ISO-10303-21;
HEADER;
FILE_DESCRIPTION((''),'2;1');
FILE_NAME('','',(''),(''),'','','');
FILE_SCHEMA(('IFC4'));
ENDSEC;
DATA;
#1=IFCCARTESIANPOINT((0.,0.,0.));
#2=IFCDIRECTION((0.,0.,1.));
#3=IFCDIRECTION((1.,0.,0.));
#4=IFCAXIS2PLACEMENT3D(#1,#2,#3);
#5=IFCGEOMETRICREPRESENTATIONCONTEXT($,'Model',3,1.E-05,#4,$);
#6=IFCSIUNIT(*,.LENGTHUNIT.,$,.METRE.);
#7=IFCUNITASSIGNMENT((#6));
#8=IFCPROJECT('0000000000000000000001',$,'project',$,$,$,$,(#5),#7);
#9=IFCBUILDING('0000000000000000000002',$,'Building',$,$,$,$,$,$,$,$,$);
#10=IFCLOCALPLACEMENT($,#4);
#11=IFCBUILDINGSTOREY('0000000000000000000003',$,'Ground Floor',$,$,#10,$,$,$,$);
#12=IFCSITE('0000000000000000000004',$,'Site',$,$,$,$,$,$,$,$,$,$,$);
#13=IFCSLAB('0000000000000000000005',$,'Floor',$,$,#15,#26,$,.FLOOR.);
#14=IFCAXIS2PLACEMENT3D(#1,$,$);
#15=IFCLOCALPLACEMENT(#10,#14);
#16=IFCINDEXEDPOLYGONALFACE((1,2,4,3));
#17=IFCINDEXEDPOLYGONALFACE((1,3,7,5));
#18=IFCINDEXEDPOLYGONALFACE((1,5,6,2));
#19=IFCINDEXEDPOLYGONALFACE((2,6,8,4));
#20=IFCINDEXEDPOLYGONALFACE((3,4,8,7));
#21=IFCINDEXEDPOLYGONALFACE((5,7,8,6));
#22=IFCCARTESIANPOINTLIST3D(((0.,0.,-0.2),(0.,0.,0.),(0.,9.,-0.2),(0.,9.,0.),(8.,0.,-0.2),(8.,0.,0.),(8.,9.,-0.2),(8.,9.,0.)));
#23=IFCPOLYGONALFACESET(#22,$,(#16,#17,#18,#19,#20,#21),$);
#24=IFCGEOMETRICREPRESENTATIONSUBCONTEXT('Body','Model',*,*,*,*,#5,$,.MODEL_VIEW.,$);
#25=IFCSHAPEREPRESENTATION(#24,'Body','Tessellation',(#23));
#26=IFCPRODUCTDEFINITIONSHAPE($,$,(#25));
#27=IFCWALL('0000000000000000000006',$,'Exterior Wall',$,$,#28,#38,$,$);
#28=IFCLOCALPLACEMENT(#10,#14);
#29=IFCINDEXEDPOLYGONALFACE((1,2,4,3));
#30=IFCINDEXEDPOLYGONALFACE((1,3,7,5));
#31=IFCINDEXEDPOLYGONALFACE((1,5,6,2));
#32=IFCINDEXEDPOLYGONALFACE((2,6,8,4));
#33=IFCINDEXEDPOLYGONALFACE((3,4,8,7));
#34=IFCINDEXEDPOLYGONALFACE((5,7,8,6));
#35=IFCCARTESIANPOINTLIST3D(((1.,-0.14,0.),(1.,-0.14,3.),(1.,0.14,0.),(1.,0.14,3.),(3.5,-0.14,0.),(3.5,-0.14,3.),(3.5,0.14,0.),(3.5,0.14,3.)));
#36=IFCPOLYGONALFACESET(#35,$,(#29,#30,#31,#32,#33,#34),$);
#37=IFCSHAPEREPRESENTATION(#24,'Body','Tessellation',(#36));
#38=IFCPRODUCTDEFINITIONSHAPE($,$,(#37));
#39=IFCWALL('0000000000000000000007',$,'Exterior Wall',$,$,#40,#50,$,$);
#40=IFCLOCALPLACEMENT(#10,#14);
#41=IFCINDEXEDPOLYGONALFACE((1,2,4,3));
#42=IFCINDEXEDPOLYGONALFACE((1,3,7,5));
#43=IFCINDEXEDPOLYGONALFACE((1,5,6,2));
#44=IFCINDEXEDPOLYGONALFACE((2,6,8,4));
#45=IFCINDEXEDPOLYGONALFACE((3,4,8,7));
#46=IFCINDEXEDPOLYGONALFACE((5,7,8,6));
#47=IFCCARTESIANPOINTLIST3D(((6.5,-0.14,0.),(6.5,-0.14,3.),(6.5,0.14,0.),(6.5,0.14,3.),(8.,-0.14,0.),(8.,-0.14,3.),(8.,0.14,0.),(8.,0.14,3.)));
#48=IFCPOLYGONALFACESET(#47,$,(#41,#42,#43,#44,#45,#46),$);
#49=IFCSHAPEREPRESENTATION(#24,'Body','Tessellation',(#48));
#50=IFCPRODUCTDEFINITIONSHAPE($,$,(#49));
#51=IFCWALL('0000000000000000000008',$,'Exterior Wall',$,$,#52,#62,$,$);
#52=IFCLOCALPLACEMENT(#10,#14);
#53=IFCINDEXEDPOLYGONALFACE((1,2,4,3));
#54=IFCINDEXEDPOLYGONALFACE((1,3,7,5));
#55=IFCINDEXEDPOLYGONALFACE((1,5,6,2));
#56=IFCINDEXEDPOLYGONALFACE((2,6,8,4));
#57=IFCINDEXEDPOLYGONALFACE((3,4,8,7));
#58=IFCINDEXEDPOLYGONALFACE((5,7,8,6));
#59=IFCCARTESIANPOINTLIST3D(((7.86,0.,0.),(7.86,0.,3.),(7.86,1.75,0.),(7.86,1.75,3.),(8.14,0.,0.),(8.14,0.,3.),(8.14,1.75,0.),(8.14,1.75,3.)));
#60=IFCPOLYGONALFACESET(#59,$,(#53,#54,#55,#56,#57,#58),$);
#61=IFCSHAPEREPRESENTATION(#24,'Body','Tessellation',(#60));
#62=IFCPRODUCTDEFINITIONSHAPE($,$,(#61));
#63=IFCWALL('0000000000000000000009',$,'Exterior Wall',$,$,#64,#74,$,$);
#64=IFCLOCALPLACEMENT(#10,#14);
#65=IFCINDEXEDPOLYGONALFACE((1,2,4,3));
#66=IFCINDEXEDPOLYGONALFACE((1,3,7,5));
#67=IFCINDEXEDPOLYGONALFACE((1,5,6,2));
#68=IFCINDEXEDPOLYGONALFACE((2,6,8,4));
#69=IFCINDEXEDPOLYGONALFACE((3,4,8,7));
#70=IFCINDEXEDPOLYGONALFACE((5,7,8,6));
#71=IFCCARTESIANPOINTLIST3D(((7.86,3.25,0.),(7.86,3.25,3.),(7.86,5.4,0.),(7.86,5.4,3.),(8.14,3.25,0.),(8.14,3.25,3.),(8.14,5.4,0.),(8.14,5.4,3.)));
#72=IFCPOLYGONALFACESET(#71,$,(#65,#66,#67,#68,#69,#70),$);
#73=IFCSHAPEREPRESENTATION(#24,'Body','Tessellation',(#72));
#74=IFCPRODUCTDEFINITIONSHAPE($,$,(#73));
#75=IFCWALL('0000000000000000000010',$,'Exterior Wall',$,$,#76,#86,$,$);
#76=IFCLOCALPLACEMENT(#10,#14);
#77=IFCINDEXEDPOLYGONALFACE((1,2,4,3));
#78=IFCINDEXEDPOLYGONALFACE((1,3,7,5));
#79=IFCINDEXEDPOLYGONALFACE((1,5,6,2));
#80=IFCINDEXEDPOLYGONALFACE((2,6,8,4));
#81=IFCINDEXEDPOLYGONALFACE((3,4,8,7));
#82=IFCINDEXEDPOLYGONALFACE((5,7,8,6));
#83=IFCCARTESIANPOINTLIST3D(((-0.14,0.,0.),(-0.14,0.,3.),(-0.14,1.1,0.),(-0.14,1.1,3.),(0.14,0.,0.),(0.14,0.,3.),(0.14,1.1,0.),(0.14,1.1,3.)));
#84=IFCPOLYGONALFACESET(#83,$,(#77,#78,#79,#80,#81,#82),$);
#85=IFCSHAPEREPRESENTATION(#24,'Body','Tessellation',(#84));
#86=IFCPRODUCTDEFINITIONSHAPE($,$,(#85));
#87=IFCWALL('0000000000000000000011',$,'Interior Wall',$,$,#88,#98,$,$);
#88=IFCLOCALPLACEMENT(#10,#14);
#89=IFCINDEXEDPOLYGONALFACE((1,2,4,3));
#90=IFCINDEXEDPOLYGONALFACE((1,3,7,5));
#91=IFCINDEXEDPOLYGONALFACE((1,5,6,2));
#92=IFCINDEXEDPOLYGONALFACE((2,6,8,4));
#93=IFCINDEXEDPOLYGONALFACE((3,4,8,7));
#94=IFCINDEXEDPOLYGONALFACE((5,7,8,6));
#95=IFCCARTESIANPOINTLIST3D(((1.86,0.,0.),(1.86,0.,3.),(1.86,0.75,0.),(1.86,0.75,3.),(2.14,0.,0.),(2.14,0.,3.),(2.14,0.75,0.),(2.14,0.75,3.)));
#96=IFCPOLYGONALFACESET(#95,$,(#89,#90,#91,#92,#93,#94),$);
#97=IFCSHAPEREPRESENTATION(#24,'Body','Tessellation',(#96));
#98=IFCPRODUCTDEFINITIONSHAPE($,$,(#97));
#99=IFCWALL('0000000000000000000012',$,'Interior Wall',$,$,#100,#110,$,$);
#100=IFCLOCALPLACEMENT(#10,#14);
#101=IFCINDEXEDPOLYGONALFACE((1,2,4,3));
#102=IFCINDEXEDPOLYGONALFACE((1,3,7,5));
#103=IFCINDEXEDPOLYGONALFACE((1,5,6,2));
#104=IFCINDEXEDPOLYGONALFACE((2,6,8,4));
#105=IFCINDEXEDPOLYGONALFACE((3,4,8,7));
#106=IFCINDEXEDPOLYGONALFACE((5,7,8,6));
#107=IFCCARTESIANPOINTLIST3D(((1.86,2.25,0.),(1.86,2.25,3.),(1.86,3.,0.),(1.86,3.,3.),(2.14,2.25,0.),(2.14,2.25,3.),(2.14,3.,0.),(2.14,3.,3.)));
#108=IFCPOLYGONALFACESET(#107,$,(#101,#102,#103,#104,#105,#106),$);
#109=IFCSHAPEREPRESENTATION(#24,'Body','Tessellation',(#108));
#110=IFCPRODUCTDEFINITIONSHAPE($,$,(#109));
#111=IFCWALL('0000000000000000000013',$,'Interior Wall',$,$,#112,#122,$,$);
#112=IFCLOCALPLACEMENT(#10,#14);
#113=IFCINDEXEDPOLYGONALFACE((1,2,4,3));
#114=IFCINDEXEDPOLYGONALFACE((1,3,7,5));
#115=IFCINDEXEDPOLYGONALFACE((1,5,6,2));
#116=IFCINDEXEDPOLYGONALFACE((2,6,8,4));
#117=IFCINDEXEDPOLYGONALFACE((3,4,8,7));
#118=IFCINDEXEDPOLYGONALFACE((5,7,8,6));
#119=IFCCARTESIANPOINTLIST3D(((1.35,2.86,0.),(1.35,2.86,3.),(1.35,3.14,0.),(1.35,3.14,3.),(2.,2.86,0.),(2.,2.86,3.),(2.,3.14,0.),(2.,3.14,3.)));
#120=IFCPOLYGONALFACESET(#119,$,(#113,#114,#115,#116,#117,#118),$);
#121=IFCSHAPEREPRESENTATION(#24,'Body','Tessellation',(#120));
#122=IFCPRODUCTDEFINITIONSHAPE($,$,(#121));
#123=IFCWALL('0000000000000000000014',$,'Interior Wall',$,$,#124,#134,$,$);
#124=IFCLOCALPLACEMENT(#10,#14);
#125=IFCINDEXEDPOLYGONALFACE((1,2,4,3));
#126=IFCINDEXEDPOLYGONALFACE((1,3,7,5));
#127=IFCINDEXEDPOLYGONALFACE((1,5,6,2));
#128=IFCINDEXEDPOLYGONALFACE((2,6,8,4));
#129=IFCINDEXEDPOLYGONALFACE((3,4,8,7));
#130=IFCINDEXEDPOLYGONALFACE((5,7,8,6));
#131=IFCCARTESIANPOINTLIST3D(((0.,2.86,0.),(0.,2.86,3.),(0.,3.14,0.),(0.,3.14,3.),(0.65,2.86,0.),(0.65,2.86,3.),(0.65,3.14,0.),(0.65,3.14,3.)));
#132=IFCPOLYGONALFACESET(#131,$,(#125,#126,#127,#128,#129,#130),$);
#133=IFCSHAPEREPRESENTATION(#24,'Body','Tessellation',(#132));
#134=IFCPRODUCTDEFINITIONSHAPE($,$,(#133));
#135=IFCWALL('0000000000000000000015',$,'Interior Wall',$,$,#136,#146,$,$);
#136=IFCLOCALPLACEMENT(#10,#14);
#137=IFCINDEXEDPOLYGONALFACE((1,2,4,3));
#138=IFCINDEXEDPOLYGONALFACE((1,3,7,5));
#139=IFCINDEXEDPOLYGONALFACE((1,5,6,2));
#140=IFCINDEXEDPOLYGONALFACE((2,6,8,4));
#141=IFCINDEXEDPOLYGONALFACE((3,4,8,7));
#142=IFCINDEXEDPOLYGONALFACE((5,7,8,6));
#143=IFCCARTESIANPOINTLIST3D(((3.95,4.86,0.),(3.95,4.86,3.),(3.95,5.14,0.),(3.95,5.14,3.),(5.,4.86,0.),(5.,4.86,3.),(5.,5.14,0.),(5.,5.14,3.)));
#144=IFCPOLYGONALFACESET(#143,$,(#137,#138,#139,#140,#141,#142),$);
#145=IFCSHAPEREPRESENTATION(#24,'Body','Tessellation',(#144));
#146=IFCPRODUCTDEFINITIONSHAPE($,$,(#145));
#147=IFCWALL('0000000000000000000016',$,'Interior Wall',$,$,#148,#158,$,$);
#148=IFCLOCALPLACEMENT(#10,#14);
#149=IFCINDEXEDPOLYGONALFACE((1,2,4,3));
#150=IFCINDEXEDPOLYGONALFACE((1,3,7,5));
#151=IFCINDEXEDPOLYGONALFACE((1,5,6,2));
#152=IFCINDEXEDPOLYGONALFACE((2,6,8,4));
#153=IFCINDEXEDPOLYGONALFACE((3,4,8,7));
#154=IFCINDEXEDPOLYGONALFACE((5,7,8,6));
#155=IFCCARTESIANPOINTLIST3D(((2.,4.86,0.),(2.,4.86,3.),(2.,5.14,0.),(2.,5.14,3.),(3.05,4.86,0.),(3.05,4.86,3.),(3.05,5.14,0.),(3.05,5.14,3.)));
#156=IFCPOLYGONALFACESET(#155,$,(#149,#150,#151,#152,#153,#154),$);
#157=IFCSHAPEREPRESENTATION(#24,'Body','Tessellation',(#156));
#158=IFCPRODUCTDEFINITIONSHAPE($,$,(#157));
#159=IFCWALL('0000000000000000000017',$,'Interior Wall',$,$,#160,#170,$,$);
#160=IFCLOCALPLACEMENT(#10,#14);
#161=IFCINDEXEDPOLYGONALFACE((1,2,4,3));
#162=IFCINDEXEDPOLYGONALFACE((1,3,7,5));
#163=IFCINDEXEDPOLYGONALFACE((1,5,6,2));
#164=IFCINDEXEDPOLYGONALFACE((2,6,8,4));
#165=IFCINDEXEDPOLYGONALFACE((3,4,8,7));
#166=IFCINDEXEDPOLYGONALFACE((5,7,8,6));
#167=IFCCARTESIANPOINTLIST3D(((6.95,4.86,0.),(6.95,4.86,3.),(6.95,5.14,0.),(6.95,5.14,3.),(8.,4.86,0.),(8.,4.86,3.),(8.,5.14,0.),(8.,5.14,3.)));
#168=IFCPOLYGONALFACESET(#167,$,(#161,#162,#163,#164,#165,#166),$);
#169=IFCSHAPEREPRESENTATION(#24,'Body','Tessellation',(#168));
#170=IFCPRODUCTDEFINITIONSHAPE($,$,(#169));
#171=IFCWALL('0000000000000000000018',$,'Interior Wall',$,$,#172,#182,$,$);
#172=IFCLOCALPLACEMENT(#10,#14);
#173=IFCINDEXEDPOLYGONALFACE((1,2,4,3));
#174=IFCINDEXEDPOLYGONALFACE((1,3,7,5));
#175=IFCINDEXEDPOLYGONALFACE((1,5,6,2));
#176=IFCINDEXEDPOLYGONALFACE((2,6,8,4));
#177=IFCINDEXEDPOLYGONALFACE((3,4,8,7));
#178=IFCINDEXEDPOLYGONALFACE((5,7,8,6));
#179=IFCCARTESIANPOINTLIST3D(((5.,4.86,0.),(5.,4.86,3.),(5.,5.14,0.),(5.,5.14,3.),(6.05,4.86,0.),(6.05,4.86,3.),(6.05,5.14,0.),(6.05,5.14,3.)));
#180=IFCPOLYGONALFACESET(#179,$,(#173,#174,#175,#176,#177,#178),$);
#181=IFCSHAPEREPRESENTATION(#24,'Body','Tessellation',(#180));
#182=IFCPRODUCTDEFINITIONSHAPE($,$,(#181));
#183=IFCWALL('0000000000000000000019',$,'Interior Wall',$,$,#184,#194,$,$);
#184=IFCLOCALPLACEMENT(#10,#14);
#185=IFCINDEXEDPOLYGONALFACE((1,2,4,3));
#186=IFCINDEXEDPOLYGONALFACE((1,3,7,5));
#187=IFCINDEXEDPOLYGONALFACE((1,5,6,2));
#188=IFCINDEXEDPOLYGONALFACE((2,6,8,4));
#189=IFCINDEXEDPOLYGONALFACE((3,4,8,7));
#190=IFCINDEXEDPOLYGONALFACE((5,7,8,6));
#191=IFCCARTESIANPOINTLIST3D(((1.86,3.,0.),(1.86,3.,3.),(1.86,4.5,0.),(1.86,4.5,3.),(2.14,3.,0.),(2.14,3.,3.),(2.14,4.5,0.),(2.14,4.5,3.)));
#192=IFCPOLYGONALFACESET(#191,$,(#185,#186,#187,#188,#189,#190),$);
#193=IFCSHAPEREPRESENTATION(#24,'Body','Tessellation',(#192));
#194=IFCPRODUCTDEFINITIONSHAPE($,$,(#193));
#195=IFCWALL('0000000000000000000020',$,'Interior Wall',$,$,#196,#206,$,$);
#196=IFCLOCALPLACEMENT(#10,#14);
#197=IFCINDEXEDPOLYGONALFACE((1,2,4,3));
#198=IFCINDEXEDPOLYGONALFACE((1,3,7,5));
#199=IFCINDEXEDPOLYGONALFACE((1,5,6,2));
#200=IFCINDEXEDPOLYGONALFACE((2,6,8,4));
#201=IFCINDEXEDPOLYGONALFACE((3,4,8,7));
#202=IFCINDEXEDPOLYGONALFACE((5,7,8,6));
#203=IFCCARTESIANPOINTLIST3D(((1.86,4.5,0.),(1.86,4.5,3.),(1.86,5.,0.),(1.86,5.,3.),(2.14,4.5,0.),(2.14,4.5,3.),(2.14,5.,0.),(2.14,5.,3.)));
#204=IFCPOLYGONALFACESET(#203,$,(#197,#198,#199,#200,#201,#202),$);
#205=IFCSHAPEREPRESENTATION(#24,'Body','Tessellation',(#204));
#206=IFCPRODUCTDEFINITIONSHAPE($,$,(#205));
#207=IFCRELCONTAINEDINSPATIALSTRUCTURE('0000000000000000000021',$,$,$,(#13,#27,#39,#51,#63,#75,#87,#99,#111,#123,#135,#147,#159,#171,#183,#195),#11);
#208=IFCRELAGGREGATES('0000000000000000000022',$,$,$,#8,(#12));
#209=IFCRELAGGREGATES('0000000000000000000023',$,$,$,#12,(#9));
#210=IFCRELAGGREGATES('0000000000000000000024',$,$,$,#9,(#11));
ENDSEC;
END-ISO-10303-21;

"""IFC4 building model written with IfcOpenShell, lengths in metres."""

from ifc_helpers import new_model, si_unit, frame, origin_with_axes, place, context, subcontext, project, spatial, indexed_curve, outline, extrude, element, save


model = new_model("IFC4")

# Units and contexts
model_context = context("Model", 3, precision=1e-05, world=origin_with_axes())
body_context = subcontext(model_context, "Body", "Model", "MODEL_VIEW")
ifc_project = project(units=[si_unit("LENGTHUNIT", "METRE")], contexts=[model_context])

# Site, building, storey
site = spatial("IfcSite", under=ifc_project, Name="Site")
building = spatial("IfcBuilding", under=site, Name="Building")
storey_placement = place(None, origin_with_axes())
storey = spatial("IfcBuildingStorey", under=building, at=storey_placement, Name="Ground Floor")

# Slab
slab_placement = place(storey_placement, frame((0.0, 0.0, -0.2), z_axis=(0.0, 0.0, 1.0), x_axis=(1.0, 0.0, 0.0)))
element("IfcSlab", 1, at=slab_placement, inside=storey, Name="Floor", PredefinedType="FLOOR", context=body_context, shape_type="SweptSolid", body=[
    extrude(outline(indexed_curve([(0.0, 0.0), (8.0, 0.0), (8.0, 9.0), (0.0, 9.0)])), None, (0.0, 0.0, 1.0), 0.2),
])

# Walls
wall_1_placement = place(storey_placement, frame((1.0, 0.0, 0.0), z_axis=(0.0, 0.0, 1.0), x_axis=(1.0, 0.0, 0.0)))
element("IfcWall", 2, at=wall_1_placement, inside=storey, Name="Exterior Wall", context=body_context, shape_type="SweptSolid", body=[
    extrude(outline(indexed_curve([(0.0, 0.0), (0.0, 0.28), (2.5, 0.28), (2.5, 0.0), (0.0, 0.0)], self_intersect=False)), frame((0.0, -0.14, 0.0), z_axis=(0.0, 0.0, 1.0), x_axis=(1.0, 0.0, 0.0)), (0.0, 0.0, 1.0), 3.0),
])
wall_2_placement = place(storey_placement, frame((6.5, 0.0, 0.0), z_axis=(0.0, 0.0, 1.0), x_axis=(1.0, 0.0, 0.0)))
element("IfcWall", 3, at=wall_2_placement, inside=storey, Name="Exterior Wall", context=body_context, shape_type="SweptSolid", body=[
    extrude(outline(indexed_curve([(0.0, 0.0), (0.0, 0.28), (1.5, 0.28), (1.5, 0.0), (0.0, 0.0)], self_intersect=False)), frame((0.0, -0.14, 0.0), z_axis=(0.0, 0.0, 1.0), x_axis=(1.0, 0.0, 0.0)), (0.0, 0.0, 1.0), 3.0),
])
wall_3_placement = place(storey_placement, frame((8.0, 0.0, 0.0), z_axis=(0.0, 0.0, 1.0), x_axis=(0.0, 1.0, 0.0)))
element("IfcWall", 4, at=wall_3_placement, inside=storey, Name="Exterior Wall", context=body_context, shape_type="SweptSolid", body=[
    extrude(outline(indexed_curve([(0.0, 0.0), (0.0, 0.28), (1.75, 0.28), (1.75, 0.0), (0.0, 0.0)], self_intersect=False)), frame((0.0, -0.14, 0.0), z_axis=(0.0, 0.0, 1.0), x_axis=(1.0, 0.0, 0.0)), (0.0, 0.0, 1.0), 3.0),
])
wall_4_placement = place(storey_placement, frame((8.0, 3.25, 0.0), z_axis=(0.0, 0.0, 1.0), x_axis=(0.0, 1.0, 0.0)))
element("IfcWall", 5, at=wall_4_placement, inside=storey, Name="Exterior Wall", context=body_context, shape_type="SweptSolid", body=[
    extrude(outline(indexed_curve([(0.0, 0.0), (0.0, 0.28), (2.15, 0.28), (2.15, 0.0), (0.0, 0.0)], self_intersect=False)), frame((0.0, -0.14, 0.0), z_axis=(0.0, 0.0, 1.0), x_axis=(1.0, 0.0, 0.0)), (0.0, 0.0, 1.0), 3.0),
])
wall_5_placement = place(storey_placement, frame((0.0, 1.1, 0.0), z_axis=(0.0, 0.0, 1.0), x_axis=(0.0, -1.0, 0.0)))
element("IfcWall", 6, at=wall_5_placement, inside=storey, Name="Exterior Wall", context=body_context, shape_type="SweptSolid", body=[
    extrude(outline(indexed_curve([(0.0, 0.0), (0.0, 0.28), (1.1, 0.28), (1.1, 0.0), (0.0, 0.0)], self_intersect=False)), frame((0.0, -0.14, 0.0), z_axis=(0.0, 0.0, 1.0), x_axis=(1.0, 0.0, 0.0)), (0.0, 0.0, 1.0), 3.0),
])
for number, where, z_axis, x_axis, name in (
    (7, (2.0, 0.0, 0.0), (0.0, 0.0, 1.0), (0.0, 1.0, 0.0), "Interior Wall"),
    (8, (2.0, 2.25, 0.0), (0.0, 0.0, 1.0), (0.0, 1.0, 0.0), "Interior Wall"),
):
    element("IfcWall", number, at=place(storey_placement, frame(where, z_axis=z_axis, x_axis=x_axis)), inside=storey, Name=name, context=body_context, shape_type="SweptSolid", body=[
        extrude(outline(indexed_curve([(0.0, 0.0), (0.0, 0.28), (0.75, 0.28), (0.75, 0.0), (0.0, 0.0)], self_intersect=False)), frame((0.0, -0.14, 0.0), z_axis=(0.0, 0.0, 1.0), x_axis=(1.0, 0.0, 0.0)), (0.0, 0.0, 1.0), 3.0),
    ])
for number, where, z_axis, x_axis, name in (
    (9, (2.0, 3.0, 0.0), (0.0, 0.0, 1.0), (-1.0, 0.0, 0.0), "Interior Wall"),
    (10, (0.65, 3.0, 0.0), (0.0, 0.0, 1.0), (-1.0, 0.0, 0.0), "Interior Wall"),
):
    element("IfcWall", number, at=place(storey_placement, frame(where, z_axis=z_axis, x_axis=x_axis)), inside=storey, Name=name, context=body_context, shape_type="SweptSolid", body=[
        extrude(outline(indexed_curve([(0.0, 0.0), (0.0, 0.28), (0.65, 0.28), (0.65, 0.0), (0.0, 0.0)], self_intersect=False)), frame((0.0, -0.14, 0.0), z_axis=(0.0, 0.0, 1.0), x_axis=(1.0, 0.0, 0.0)), (0.0, 0.0, 1.0), 3.0),
    ])
for number, where, z_axis, x_axis, name in (
    (11, (5.0, 5.0, 0.0), (0.0, 0.0, 1.0), (-1.0, 0.0, 0.0), "Interior Wall"),
    (12, (3.05, 5.0, 0.0), (0.0, 0.0, 1.0), (-1.0, 0.0, 0.0), "Interior Wall"),
    (13, (8.0, 5.0, 0.0), (0.0, 0.0, 1.0), (-1.0, 0.0, 0.0), "Interior Wall"),
    (14, (6.05, 5.0, 0.0), (0.0, 0.0, 1.0), (-1.0, 0.0, 0.0), "Interior Wall"),
):
    element("IfcWall", number, at=place(storey_placement, frame(where, z_axis=z_axis, x_axis=x_axis)), inside=storey, Name=name, context=body_context, shape_type="SweptSolid", body=[
        extrude(outline(indexed_curve([(0.0, 0.0), (0.0, 0.28), (1.05, 0.28), (1.05, 0.0), (0.0, 0.0)], self_intersect=False)), frame((0.0, -0.14, 0.0), z_axis=(0.0, 0.0, 1.0), x_axis=(1.0, 0.0, 0.0)), (0.0, 0.0, 1.0), 3.0),
    ])
wall_6_placement = place(storey_placement, frame((2.0, 4.5, 0.0), z_axis=(0.0, 0.0, 1.0), x_axis=(0.0, -1.0, 0.0)))
element("IfcWall", 15, at=wall_6_placement, inside=storey, Name="Interior Wall", context=body_context, shape_type="SweptSolid", body=[
    extrude(outline(indexed_curve([(0.0, 0.0), (0.0, 0.28), (1.5, 0.28), (1.5, 0.0), (0.0, 0.0)], self_intersect=False)), frame((0.0, -0.14, 0.0), z_axis=(0.0, 0.0, 1.0), x_axis=(1.0, 0.0, 0.0)), (0.0, 0.0, 1.0), 3.0),
])
wall_7_placement = place(storey_placement, frame((2.0, 5.0, 0.0), z_axis=(0.0, 0.0, 1.0), x_axis=(0.0, -1.0, 0.0)))
element("IfcWall", 16, at=wall_7_placement, inside=storey, Name="Interior Wall", context=body_context, shape_type="SweptSolid", body=[
    extrude(outline(indexed_curve([(0.0, 0.0), (0.0, 0.28), (0.5, 0.28), (0.5, 0.0), (0.0, 0.0)], self_intersect=False)), frame((0.0, -0.14, 0.0), z_axis=(0.0, 0.0, 1.0), x_axis=(1.0, 0.0, 0.0)), (0.0, 0.0, 1.0), 3.0),
])

save(model, "model.ifc")
